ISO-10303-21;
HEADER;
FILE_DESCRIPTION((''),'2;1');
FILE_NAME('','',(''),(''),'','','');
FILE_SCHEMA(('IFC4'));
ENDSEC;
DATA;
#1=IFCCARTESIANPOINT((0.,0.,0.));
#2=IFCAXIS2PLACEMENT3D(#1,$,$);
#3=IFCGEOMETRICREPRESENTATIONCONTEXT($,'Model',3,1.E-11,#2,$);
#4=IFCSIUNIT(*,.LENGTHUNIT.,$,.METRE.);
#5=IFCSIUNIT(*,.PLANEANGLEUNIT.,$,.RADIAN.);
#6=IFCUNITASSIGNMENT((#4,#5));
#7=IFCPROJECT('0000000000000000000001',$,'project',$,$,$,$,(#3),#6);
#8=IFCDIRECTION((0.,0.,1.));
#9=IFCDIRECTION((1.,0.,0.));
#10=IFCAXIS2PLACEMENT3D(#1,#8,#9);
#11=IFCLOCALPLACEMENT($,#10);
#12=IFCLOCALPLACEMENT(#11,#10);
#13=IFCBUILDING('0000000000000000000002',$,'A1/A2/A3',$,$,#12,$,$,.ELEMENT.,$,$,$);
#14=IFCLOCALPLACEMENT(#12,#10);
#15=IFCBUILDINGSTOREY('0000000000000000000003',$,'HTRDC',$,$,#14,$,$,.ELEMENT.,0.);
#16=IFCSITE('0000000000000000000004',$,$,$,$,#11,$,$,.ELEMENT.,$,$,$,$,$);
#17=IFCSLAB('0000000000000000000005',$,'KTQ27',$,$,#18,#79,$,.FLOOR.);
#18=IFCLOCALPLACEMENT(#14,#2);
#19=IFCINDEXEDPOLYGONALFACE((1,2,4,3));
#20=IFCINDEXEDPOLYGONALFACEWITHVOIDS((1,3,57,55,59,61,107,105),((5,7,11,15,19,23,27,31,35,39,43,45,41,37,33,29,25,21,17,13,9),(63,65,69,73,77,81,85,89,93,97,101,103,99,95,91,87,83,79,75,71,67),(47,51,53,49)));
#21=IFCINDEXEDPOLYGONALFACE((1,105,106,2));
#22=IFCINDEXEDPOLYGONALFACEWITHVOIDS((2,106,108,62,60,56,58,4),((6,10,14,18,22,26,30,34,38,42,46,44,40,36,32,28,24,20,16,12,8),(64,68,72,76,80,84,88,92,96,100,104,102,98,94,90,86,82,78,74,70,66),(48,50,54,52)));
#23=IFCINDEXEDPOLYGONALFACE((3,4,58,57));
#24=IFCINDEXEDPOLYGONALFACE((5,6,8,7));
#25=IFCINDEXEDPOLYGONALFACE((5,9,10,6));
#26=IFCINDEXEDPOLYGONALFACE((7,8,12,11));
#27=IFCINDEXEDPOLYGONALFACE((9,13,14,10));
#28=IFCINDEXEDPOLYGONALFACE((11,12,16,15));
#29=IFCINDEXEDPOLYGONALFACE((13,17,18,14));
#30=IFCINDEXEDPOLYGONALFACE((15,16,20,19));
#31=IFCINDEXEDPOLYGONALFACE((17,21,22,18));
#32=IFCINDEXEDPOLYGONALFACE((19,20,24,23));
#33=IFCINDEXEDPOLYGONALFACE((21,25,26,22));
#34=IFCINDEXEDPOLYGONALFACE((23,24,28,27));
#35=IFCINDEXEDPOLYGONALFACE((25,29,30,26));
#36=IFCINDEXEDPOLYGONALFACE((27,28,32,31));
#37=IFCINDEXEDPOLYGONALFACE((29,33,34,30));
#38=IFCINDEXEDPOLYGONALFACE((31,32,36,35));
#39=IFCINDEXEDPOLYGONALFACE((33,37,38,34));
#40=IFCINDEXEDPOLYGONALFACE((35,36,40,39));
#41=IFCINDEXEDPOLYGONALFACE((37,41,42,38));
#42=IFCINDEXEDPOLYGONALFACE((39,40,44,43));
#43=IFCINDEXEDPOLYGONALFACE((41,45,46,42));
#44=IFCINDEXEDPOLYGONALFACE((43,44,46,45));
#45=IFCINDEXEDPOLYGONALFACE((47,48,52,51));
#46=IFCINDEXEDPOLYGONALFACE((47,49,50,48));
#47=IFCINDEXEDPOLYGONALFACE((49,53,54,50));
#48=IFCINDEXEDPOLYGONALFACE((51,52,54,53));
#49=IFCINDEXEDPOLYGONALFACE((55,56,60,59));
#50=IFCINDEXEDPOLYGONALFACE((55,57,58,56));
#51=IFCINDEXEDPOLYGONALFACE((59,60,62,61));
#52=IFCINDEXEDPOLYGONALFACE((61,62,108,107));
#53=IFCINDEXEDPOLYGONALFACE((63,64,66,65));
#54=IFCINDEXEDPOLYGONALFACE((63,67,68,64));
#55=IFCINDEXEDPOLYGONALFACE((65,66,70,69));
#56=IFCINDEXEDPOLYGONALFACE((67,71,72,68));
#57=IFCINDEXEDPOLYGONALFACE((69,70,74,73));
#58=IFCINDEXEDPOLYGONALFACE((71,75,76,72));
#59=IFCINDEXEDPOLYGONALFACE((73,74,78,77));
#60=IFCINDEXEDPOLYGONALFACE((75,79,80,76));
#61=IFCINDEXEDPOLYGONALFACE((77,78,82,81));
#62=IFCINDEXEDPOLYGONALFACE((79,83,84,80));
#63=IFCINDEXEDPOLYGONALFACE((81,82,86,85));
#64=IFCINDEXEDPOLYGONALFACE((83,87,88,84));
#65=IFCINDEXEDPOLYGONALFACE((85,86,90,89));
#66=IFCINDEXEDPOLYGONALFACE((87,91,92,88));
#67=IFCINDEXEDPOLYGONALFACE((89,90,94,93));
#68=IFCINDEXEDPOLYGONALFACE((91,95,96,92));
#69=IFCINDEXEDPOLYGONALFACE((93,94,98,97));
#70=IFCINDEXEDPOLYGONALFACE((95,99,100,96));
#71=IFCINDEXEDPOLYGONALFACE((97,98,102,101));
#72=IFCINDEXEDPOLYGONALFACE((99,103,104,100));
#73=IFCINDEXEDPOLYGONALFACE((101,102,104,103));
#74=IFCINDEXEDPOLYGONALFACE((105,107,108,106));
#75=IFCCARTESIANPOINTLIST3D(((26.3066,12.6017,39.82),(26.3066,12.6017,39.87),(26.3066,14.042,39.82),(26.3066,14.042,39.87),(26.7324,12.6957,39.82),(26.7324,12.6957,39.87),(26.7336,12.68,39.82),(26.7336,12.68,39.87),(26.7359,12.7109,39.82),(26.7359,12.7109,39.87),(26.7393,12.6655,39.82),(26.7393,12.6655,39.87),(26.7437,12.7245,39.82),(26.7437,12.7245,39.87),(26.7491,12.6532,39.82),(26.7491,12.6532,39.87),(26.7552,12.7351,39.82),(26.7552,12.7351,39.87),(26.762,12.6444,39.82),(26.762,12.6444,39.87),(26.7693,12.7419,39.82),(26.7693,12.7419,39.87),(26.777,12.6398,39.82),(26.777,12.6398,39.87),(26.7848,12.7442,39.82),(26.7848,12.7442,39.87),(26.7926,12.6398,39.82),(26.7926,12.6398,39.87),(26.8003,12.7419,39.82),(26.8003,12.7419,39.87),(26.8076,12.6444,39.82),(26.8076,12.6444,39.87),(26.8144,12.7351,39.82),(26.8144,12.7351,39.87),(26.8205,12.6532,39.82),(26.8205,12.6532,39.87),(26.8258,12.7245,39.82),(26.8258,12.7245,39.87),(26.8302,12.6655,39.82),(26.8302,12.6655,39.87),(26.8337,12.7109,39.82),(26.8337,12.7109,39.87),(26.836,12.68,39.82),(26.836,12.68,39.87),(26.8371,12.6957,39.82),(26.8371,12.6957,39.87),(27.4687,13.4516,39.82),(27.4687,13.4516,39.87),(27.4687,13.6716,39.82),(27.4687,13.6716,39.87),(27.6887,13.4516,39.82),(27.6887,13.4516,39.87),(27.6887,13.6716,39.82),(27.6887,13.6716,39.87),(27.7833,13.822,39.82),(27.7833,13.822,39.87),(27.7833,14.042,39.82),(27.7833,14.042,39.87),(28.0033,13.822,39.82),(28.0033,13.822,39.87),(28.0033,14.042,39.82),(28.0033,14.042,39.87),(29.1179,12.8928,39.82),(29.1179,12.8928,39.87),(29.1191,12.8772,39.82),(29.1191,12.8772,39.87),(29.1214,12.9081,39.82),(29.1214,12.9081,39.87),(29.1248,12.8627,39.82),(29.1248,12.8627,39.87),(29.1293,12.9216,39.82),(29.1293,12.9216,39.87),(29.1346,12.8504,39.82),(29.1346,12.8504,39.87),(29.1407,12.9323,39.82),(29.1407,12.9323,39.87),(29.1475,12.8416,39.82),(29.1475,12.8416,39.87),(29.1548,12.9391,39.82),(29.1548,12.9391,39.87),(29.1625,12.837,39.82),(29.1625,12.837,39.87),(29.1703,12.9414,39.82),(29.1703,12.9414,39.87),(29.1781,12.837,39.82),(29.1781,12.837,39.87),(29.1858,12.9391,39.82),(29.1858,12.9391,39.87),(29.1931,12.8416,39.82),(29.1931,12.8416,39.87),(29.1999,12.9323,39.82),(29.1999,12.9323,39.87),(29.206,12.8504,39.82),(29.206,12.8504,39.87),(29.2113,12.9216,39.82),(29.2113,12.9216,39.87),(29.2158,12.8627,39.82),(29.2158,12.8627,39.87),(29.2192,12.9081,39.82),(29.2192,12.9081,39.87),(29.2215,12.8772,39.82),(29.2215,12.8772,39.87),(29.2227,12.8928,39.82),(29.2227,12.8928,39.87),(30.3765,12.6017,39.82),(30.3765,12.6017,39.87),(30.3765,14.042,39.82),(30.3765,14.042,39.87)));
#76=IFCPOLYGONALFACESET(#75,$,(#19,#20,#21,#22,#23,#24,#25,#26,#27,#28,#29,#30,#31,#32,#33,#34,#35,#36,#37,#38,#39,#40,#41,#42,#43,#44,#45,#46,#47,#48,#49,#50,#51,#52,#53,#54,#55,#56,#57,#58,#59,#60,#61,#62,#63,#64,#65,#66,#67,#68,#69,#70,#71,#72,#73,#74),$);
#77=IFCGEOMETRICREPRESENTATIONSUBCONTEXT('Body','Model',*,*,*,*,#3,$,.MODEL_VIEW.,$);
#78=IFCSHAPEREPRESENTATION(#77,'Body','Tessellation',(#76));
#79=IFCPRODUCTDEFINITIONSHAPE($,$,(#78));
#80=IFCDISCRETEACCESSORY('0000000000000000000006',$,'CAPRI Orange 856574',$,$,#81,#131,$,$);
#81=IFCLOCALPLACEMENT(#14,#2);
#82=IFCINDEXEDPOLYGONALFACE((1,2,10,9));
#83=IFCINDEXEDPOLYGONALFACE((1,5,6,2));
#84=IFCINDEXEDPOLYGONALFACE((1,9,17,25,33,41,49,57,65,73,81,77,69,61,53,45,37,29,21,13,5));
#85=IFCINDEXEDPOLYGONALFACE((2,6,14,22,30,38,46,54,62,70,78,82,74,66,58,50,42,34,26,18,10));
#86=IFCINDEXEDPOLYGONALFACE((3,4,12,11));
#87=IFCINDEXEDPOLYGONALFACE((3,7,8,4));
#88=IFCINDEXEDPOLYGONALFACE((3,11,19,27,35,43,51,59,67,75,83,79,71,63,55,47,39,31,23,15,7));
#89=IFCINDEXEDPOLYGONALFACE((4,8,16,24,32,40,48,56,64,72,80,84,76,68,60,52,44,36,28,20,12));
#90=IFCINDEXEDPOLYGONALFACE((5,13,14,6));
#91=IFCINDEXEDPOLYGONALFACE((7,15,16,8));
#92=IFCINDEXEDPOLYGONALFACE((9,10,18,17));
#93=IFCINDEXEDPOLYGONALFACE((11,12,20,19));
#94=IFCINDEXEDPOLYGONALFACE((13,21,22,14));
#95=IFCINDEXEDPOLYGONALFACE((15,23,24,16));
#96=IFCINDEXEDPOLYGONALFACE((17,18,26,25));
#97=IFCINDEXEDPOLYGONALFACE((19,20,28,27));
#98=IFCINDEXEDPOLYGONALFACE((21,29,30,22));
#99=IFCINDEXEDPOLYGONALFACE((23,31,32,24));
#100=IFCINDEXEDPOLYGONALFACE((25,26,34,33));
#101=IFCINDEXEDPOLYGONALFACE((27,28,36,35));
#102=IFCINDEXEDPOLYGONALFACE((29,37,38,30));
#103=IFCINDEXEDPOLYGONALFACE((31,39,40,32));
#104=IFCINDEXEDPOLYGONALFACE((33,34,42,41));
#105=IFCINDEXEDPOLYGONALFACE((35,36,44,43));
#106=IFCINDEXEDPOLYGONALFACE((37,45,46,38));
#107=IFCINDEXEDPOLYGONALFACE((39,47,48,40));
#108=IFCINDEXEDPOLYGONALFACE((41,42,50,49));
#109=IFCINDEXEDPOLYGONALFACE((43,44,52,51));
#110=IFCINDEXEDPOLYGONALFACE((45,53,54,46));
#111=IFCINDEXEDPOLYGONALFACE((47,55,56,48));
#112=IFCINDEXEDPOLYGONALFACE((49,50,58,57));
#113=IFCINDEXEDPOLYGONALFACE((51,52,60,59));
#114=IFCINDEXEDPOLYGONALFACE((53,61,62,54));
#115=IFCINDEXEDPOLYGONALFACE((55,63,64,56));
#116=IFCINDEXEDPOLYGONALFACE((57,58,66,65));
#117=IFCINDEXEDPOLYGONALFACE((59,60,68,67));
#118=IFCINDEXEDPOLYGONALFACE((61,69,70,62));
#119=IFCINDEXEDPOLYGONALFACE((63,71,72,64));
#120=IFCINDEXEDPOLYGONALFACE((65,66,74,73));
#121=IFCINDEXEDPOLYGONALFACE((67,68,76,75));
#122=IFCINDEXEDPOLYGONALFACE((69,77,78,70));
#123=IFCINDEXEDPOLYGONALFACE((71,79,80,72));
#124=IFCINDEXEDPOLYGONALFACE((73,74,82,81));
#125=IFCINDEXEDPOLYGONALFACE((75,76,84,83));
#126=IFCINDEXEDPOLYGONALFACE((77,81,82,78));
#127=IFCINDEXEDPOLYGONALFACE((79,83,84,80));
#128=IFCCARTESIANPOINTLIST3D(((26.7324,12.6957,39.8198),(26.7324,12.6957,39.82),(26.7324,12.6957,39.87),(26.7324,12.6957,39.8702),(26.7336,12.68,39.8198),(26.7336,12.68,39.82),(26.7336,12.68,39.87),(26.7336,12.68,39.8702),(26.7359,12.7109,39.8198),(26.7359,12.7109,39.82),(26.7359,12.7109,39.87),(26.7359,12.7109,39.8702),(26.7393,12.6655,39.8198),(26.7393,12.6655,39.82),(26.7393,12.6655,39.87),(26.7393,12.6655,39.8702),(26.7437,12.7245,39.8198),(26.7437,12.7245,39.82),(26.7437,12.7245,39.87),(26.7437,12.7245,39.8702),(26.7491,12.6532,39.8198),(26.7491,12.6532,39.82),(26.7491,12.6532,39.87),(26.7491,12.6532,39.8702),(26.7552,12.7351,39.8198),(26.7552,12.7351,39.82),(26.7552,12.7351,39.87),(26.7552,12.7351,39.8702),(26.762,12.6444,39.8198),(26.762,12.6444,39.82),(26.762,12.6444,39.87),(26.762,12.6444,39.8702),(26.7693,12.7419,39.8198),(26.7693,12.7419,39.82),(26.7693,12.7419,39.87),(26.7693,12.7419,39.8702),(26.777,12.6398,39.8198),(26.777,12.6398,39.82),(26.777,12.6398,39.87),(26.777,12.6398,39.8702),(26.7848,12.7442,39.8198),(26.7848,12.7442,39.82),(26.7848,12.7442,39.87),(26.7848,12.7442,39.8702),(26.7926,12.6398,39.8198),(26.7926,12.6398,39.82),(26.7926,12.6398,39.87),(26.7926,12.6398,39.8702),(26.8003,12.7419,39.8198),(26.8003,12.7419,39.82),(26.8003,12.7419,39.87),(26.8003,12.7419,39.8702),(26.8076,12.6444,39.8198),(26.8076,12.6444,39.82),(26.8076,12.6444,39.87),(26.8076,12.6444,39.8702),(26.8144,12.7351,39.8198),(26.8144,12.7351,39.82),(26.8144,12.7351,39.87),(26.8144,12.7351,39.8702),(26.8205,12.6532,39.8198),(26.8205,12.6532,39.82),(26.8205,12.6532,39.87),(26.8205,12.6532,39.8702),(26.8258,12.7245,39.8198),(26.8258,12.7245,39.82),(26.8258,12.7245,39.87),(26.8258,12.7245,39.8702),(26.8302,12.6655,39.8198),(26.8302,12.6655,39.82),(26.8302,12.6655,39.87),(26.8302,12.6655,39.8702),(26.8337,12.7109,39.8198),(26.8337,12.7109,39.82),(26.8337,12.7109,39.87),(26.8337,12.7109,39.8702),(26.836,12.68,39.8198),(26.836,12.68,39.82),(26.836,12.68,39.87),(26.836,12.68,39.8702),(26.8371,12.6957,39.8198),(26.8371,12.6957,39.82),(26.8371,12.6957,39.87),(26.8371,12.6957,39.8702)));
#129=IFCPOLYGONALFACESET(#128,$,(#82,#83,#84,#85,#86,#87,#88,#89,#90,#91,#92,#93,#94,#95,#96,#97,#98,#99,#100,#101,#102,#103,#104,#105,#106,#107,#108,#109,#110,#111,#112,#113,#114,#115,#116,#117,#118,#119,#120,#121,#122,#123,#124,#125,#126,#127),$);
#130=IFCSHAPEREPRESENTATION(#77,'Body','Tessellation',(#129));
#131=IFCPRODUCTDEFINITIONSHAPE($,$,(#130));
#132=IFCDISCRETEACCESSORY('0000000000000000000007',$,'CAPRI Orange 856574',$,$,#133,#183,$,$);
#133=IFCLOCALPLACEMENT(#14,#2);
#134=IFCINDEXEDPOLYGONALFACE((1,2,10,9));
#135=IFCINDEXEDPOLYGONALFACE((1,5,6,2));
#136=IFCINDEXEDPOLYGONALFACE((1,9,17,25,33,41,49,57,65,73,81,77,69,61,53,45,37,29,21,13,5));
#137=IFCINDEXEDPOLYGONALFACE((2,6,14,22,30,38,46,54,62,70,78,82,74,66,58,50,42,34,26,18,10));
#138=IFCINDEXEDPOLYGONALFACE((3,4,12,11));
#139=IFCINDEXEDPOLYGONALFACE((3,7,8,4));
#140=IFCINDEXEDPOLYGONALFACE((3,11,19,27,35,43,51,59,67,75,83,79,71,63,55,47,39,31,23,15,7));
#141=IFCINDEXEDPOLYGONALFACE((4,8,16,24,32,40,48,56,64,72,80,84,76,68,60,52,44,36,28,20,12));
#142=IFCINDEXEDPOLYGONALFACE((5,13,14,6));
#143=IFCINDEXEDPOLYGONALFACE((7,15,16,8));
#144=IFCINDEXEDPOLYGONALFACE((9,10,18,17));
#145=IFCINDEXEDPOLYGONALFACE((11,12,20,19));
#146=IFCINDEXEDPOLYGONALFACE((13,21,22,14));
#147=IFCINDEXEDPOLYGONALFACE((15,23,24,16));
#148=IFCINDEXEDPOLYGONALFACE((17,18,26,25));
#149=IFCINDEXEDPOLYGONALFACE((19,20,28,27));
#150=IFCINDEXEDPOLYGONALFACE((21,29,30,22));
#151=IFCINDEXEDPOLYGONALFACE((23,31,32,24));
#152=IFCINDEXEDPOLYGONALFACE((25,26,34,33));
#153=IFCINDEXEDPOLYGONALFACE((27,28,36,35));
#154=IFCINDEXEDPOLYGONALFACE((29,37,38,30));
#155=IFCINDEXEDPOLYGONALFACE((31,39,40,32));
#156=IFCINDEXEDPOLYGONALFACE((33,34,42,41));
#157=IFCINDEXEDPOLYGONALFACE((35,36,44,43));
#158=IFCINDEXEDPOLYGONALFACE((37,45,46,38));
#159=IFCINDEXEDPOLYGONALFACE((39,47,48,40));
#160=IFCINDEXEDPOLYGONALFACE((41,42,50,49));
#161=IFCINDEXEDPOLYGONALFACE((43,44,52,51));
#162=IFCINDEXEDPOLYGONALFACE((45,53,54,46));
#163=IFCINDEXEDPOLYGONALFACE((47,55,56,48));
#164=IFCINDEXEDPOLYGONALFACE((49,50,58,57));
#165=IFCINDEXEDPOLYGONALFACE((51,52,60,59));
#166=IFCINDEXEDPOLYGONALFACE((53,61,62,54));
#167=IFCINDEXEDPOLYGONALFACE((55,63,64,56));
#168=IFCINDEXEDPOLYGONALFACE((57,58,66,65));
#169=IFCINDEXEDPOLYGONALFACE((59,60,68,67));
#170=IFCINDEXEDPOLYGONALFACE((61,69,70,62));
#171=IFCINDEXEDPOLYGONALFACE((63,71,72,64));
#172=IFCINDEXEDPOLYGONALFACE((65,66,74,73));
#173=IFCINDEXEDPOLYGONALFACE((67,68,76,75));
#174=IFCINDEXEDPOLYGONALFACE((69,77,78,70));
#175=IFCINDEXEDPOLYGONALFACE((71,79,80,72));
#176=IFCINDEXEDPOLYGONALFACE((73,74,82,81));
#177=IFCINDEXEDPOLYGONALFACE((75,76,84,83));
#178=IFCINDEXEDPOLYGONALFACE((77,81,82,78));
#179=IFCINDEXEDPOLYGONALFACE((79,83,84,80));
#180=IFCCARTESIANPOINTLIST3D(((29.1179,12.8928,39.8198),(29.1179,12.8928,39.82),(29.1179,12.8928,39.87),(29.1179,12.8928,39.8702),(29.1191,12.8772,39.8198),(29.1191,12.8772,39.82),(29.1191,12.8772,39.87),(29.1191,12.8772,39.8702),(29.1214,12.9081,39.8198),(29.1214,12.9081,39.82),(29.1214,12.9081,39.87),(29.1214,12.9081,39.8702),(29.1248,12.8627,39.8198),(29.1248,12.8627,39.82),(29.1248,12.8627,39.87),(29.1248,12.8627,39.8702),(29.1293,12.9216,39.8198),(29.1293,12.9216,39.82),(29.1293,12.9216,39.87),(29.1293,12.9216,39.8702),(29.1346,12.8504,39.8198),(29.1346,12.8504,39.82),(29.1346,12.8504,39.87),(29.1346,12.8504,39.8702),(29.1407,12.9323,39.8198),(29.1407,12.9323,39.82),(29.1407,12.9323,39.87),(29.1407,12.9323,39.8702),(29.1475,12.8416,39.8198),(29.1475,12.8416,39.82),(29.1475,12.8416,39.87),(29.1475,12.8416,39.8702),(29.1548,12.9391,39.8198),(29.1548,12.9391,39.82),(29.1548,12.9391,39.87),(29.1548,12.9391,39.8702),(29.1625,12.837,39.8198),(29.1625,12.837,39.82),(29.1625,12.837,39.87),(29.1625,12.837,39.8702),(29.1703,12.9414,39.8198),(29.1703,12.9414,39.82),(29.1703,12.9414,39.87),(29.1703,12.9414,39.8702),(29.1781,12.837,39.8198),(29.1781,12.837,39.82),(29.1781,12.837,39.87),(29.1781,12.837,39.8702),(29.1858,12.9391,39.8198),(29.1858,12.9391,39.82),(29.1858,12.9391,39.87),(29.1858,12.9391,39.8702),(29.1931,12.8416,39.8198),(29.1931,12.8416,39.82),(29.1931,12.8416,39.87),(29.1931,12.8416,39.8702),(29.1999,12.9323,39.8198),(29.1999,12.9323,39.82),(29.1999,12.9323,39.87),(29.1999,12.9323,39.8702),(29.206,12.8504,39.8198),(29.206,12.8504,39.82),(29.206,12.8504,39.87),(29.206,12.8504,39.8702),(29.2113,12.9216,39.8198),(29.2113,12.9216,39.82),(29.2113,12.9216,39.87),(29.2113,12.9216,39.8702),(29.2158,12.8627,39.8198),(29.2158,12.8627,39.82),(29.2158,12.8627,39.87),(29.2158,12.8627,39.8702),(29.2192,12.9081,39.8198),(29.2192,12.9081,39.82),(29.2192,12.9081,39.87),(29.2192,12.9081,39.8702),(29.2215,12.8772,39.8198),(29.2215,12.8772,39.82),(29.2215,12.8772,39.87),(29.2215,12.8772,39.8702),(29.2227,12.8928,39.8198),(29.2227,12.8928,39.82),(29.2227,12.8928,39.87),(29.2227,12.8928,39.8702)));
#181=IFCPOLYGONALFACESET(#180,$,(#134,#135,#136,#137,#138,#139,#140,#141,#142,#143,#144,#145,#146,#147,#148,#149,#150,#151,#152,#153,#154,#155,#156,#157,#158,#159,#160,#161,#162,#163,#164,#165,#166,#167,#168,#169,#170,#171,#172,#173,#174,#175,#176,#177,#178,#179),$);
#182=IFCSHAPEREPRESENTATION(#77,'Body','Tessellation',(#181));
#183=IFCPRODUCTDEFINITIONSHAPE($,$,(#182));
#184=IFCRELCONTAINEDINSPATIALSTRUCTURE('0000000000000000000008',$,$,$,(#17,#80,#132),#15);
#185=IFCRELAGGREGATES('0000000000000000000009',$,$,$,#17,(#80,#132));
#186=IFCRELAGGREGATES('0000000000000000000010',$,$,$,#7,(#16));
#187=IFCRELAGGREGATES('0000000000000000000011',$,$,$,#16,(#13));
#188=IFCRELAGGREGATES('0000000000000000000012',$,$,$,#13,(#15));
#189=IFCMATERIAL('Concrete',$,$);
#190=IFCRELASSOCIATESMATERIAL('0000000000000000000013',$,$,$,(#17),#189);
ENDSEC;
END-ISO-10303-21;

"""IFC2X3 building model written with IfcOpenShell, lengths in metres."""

from ifc_helpers import new_model, si_unit, frame, frame_2d, origin, origin_with_axes, origin_2d_with_axis, place, context, subcontext, project, spatial, polyline, circle, outline, extrude, material, element, aggregate, save


model = new_model("IFC2X3")

# Units and contexts
model_context = context("Model", 3, precision=1e-11, world=origin())
body_context = subcontext(model_context, "Body", "Model", "MODEL_VIEW")
ifc_project = project(units=[si_unit("LENGTHUNIT", "METRE"), si_unit("PLANEANGLEUNIT", "RADIAN")], contexts=[model_context])

# Site, building, storey
site_placement = place(None, origin_with_axes())
site = spatial("IfcSite", under=ifc_project, at=site_placement, CompositionType="ELEMENT")
building_placement = place(site_placement, origin_with_axes())
building = spatial("IfcBuilding", under=site, at=building_placement, Name="A1/A2/A3", CompositionType="ELEMENT")
storey_placement = place(building_placement, origin_with_axes())
storey = spatial("IfcBuildingStorey", under=building, at=storey_placement, Name="HTRDC", CompositionType="ELEMENT", Elevation=0.0)

# Shared definitions
ifc_material = material(Name="Concrete")

# Slab, openings
slab_1_placement = place(storey_placement, frame((26.3066, 12.6017, 39.82), z_axis=(0.0, 0.0, 1.0), x_axis=(1.0, 0.0, 0.0)))
slab_1 = element("IfcSlab", 1, at=slab_1_placement, inside=storey, material=ifc_material, Name="KTQ27", PredefinedType="FLOOR", context=body_context, shape_type="SweptSolid", body=[
    extrude(outline(polyline([(0.0, 0.0), (0.0, -4.0699), (1.4403, -4.0699), (1.4403, 0.0), (0.0, 0.0)])), frame((0.0, 0.0, 0.0), z_axis=(0.0, 0.0, 1.0), x_axis=(0.0, 1.0, 0.0)), (0.0, 0.0, 1.0), 0.05),
])
opening_1_placement = place(slab_1_placement, origin_with_axes())
element("IfcOpeningElement", 2, at=opening_1_placement, cuts=slab_1, ObjectType="Opening", context=body_context, shape_type="SweptSolid", body=[
    extrude(outline(polyline([(1.2203, -1.4767), (1.2203, -1.6967), (1.4403, -1.6967), (1.4403, -1.4767), (1.2203, -1.4767)])), frame((0.0, 0.0, 0.0), z_axis=(0.0, 0.0, 1.0), x_axis=(0.0, 1.0, 0.0)), (0.0, 0.0, 1.0), 0.05),
])
opening_2_placement = place(slab_1_placement, origin_with_axes())
element("IfcOpeningElement", 3, at=opening_2_placement, cuts=slab_1, ObjectType="Opening", context=body_context, shape_type="SweptSolid", body=[
    extrude(outline(polyline([(0.8499, -1.1621), (0.8499, -1.3821), (1.0699, -1.3821), (1.0699, -1.1621), (0.8499, -1.1621)])), frame((0.0, 0.0, 0.0), z_axis=(0.0, 0.0, 1.0), x_axis=(0.0, 1.0, 0.0)), (0.0, 0.0, 1.0), 0.05),
])
opening_3_placement = place(slab_1_placement, frame((0.4782, 0.09, 0.0), z_axis=(0.0, 0.0, 1.0), x_axis=(1.0, 0.0, 0.0)))
element("IfcOpeningElement", 4, at=opening_3_placement, cuts=slab_1, ObjectType="Opening", context=body_context, shape_type="SweptSolid", body=[
    extrude(circle(Radius=0.0525, at=origin_2d_with_axis()), frame((0.0, 0.0, 0.0), z_axis=(0.0, 0.0, 1.0), x_axis=(0.0, 1.0, 0.0)), (0.0, 0.0, 1.0), 0.05),
])
opening_4_placement = place(slab_1_placement, frame((2.8637, 0.2872, 0.0), z_axis=(0.0, 0.0, 1.0), x_axis=(1.0, 0.0, 0.0)))
element("IfcOpeningElement", 5, at=opening_4_placement, cuts=slab_1, ObjectType="Opening", context=body_context, shape_type="SweptSolid", body=[
    extrude(circle(Radius=0.0525, at=origin_2d_with_axis()), frame((0.0, 0.0, 0.0), z_axis=(0.0, 0.0, 1.0), x_axis=(0.0, 1.0, 0.0)), (0.0, 0.0, 1.0), 0.05),
])

# Discrete accessories
discrete_accessory_1_placement = place(storey_placement, frame((26.3066, 12.6017, 39.8199), z_axis=(0.0, 0.0, 1.0), x_axis=(1.0, 0.0, 0.0)))
discrete_accessory_1 = element("IfcDiscreteAccessory", 6, at=discrete_accessory_1_placement, inside=storey, Name="CAPRI Orange 856574", context=body_context, shape_type="SweptSolid", body=[
    extrude(circle(Radius=0.0525, at=frame_2d((0.09, -0.4782), x_axis=(1.0, 0.0))), frame((0.0, 0.0, 0.0), z_axis=(0.0, 0.0, 1.0), x_axis=(0.0, 1.0, 0.0)), (0.0, 0.0, 1.0), 0.0503),
])
discrete_accessory_2_placement = place(storey_placement, frame((26.3066, 12.6017, 39.8199), z_axis=(0.0, 0.0, 1.0), x_axis=(1.0, 0.0, 0.0)))
discrete_accessory_2 = element("IfcDiscreteAccessory", 7, at=discrete_accessory_2_placement, inside=storey, Name="CAPRI Orange 856574", context=body_context, shape_type="SweptSolid", body=[
    extrude(circle(Radius=0.0525, at=frame_2d((0.2872, -2.8637), x_axis=(1.0, 0.0))), frame((0.0, 0.0, 0.0), z_axis=(0.0, 0.0, 1.0), x_axis=(0.0, 1.0, 0.0)), (0.0, 0.0, 1.0), 0.0503),
])
aggregate(slab_1, [discrete_accessory_1, discrete_accessory_2])

save(model, "model.ifc")
